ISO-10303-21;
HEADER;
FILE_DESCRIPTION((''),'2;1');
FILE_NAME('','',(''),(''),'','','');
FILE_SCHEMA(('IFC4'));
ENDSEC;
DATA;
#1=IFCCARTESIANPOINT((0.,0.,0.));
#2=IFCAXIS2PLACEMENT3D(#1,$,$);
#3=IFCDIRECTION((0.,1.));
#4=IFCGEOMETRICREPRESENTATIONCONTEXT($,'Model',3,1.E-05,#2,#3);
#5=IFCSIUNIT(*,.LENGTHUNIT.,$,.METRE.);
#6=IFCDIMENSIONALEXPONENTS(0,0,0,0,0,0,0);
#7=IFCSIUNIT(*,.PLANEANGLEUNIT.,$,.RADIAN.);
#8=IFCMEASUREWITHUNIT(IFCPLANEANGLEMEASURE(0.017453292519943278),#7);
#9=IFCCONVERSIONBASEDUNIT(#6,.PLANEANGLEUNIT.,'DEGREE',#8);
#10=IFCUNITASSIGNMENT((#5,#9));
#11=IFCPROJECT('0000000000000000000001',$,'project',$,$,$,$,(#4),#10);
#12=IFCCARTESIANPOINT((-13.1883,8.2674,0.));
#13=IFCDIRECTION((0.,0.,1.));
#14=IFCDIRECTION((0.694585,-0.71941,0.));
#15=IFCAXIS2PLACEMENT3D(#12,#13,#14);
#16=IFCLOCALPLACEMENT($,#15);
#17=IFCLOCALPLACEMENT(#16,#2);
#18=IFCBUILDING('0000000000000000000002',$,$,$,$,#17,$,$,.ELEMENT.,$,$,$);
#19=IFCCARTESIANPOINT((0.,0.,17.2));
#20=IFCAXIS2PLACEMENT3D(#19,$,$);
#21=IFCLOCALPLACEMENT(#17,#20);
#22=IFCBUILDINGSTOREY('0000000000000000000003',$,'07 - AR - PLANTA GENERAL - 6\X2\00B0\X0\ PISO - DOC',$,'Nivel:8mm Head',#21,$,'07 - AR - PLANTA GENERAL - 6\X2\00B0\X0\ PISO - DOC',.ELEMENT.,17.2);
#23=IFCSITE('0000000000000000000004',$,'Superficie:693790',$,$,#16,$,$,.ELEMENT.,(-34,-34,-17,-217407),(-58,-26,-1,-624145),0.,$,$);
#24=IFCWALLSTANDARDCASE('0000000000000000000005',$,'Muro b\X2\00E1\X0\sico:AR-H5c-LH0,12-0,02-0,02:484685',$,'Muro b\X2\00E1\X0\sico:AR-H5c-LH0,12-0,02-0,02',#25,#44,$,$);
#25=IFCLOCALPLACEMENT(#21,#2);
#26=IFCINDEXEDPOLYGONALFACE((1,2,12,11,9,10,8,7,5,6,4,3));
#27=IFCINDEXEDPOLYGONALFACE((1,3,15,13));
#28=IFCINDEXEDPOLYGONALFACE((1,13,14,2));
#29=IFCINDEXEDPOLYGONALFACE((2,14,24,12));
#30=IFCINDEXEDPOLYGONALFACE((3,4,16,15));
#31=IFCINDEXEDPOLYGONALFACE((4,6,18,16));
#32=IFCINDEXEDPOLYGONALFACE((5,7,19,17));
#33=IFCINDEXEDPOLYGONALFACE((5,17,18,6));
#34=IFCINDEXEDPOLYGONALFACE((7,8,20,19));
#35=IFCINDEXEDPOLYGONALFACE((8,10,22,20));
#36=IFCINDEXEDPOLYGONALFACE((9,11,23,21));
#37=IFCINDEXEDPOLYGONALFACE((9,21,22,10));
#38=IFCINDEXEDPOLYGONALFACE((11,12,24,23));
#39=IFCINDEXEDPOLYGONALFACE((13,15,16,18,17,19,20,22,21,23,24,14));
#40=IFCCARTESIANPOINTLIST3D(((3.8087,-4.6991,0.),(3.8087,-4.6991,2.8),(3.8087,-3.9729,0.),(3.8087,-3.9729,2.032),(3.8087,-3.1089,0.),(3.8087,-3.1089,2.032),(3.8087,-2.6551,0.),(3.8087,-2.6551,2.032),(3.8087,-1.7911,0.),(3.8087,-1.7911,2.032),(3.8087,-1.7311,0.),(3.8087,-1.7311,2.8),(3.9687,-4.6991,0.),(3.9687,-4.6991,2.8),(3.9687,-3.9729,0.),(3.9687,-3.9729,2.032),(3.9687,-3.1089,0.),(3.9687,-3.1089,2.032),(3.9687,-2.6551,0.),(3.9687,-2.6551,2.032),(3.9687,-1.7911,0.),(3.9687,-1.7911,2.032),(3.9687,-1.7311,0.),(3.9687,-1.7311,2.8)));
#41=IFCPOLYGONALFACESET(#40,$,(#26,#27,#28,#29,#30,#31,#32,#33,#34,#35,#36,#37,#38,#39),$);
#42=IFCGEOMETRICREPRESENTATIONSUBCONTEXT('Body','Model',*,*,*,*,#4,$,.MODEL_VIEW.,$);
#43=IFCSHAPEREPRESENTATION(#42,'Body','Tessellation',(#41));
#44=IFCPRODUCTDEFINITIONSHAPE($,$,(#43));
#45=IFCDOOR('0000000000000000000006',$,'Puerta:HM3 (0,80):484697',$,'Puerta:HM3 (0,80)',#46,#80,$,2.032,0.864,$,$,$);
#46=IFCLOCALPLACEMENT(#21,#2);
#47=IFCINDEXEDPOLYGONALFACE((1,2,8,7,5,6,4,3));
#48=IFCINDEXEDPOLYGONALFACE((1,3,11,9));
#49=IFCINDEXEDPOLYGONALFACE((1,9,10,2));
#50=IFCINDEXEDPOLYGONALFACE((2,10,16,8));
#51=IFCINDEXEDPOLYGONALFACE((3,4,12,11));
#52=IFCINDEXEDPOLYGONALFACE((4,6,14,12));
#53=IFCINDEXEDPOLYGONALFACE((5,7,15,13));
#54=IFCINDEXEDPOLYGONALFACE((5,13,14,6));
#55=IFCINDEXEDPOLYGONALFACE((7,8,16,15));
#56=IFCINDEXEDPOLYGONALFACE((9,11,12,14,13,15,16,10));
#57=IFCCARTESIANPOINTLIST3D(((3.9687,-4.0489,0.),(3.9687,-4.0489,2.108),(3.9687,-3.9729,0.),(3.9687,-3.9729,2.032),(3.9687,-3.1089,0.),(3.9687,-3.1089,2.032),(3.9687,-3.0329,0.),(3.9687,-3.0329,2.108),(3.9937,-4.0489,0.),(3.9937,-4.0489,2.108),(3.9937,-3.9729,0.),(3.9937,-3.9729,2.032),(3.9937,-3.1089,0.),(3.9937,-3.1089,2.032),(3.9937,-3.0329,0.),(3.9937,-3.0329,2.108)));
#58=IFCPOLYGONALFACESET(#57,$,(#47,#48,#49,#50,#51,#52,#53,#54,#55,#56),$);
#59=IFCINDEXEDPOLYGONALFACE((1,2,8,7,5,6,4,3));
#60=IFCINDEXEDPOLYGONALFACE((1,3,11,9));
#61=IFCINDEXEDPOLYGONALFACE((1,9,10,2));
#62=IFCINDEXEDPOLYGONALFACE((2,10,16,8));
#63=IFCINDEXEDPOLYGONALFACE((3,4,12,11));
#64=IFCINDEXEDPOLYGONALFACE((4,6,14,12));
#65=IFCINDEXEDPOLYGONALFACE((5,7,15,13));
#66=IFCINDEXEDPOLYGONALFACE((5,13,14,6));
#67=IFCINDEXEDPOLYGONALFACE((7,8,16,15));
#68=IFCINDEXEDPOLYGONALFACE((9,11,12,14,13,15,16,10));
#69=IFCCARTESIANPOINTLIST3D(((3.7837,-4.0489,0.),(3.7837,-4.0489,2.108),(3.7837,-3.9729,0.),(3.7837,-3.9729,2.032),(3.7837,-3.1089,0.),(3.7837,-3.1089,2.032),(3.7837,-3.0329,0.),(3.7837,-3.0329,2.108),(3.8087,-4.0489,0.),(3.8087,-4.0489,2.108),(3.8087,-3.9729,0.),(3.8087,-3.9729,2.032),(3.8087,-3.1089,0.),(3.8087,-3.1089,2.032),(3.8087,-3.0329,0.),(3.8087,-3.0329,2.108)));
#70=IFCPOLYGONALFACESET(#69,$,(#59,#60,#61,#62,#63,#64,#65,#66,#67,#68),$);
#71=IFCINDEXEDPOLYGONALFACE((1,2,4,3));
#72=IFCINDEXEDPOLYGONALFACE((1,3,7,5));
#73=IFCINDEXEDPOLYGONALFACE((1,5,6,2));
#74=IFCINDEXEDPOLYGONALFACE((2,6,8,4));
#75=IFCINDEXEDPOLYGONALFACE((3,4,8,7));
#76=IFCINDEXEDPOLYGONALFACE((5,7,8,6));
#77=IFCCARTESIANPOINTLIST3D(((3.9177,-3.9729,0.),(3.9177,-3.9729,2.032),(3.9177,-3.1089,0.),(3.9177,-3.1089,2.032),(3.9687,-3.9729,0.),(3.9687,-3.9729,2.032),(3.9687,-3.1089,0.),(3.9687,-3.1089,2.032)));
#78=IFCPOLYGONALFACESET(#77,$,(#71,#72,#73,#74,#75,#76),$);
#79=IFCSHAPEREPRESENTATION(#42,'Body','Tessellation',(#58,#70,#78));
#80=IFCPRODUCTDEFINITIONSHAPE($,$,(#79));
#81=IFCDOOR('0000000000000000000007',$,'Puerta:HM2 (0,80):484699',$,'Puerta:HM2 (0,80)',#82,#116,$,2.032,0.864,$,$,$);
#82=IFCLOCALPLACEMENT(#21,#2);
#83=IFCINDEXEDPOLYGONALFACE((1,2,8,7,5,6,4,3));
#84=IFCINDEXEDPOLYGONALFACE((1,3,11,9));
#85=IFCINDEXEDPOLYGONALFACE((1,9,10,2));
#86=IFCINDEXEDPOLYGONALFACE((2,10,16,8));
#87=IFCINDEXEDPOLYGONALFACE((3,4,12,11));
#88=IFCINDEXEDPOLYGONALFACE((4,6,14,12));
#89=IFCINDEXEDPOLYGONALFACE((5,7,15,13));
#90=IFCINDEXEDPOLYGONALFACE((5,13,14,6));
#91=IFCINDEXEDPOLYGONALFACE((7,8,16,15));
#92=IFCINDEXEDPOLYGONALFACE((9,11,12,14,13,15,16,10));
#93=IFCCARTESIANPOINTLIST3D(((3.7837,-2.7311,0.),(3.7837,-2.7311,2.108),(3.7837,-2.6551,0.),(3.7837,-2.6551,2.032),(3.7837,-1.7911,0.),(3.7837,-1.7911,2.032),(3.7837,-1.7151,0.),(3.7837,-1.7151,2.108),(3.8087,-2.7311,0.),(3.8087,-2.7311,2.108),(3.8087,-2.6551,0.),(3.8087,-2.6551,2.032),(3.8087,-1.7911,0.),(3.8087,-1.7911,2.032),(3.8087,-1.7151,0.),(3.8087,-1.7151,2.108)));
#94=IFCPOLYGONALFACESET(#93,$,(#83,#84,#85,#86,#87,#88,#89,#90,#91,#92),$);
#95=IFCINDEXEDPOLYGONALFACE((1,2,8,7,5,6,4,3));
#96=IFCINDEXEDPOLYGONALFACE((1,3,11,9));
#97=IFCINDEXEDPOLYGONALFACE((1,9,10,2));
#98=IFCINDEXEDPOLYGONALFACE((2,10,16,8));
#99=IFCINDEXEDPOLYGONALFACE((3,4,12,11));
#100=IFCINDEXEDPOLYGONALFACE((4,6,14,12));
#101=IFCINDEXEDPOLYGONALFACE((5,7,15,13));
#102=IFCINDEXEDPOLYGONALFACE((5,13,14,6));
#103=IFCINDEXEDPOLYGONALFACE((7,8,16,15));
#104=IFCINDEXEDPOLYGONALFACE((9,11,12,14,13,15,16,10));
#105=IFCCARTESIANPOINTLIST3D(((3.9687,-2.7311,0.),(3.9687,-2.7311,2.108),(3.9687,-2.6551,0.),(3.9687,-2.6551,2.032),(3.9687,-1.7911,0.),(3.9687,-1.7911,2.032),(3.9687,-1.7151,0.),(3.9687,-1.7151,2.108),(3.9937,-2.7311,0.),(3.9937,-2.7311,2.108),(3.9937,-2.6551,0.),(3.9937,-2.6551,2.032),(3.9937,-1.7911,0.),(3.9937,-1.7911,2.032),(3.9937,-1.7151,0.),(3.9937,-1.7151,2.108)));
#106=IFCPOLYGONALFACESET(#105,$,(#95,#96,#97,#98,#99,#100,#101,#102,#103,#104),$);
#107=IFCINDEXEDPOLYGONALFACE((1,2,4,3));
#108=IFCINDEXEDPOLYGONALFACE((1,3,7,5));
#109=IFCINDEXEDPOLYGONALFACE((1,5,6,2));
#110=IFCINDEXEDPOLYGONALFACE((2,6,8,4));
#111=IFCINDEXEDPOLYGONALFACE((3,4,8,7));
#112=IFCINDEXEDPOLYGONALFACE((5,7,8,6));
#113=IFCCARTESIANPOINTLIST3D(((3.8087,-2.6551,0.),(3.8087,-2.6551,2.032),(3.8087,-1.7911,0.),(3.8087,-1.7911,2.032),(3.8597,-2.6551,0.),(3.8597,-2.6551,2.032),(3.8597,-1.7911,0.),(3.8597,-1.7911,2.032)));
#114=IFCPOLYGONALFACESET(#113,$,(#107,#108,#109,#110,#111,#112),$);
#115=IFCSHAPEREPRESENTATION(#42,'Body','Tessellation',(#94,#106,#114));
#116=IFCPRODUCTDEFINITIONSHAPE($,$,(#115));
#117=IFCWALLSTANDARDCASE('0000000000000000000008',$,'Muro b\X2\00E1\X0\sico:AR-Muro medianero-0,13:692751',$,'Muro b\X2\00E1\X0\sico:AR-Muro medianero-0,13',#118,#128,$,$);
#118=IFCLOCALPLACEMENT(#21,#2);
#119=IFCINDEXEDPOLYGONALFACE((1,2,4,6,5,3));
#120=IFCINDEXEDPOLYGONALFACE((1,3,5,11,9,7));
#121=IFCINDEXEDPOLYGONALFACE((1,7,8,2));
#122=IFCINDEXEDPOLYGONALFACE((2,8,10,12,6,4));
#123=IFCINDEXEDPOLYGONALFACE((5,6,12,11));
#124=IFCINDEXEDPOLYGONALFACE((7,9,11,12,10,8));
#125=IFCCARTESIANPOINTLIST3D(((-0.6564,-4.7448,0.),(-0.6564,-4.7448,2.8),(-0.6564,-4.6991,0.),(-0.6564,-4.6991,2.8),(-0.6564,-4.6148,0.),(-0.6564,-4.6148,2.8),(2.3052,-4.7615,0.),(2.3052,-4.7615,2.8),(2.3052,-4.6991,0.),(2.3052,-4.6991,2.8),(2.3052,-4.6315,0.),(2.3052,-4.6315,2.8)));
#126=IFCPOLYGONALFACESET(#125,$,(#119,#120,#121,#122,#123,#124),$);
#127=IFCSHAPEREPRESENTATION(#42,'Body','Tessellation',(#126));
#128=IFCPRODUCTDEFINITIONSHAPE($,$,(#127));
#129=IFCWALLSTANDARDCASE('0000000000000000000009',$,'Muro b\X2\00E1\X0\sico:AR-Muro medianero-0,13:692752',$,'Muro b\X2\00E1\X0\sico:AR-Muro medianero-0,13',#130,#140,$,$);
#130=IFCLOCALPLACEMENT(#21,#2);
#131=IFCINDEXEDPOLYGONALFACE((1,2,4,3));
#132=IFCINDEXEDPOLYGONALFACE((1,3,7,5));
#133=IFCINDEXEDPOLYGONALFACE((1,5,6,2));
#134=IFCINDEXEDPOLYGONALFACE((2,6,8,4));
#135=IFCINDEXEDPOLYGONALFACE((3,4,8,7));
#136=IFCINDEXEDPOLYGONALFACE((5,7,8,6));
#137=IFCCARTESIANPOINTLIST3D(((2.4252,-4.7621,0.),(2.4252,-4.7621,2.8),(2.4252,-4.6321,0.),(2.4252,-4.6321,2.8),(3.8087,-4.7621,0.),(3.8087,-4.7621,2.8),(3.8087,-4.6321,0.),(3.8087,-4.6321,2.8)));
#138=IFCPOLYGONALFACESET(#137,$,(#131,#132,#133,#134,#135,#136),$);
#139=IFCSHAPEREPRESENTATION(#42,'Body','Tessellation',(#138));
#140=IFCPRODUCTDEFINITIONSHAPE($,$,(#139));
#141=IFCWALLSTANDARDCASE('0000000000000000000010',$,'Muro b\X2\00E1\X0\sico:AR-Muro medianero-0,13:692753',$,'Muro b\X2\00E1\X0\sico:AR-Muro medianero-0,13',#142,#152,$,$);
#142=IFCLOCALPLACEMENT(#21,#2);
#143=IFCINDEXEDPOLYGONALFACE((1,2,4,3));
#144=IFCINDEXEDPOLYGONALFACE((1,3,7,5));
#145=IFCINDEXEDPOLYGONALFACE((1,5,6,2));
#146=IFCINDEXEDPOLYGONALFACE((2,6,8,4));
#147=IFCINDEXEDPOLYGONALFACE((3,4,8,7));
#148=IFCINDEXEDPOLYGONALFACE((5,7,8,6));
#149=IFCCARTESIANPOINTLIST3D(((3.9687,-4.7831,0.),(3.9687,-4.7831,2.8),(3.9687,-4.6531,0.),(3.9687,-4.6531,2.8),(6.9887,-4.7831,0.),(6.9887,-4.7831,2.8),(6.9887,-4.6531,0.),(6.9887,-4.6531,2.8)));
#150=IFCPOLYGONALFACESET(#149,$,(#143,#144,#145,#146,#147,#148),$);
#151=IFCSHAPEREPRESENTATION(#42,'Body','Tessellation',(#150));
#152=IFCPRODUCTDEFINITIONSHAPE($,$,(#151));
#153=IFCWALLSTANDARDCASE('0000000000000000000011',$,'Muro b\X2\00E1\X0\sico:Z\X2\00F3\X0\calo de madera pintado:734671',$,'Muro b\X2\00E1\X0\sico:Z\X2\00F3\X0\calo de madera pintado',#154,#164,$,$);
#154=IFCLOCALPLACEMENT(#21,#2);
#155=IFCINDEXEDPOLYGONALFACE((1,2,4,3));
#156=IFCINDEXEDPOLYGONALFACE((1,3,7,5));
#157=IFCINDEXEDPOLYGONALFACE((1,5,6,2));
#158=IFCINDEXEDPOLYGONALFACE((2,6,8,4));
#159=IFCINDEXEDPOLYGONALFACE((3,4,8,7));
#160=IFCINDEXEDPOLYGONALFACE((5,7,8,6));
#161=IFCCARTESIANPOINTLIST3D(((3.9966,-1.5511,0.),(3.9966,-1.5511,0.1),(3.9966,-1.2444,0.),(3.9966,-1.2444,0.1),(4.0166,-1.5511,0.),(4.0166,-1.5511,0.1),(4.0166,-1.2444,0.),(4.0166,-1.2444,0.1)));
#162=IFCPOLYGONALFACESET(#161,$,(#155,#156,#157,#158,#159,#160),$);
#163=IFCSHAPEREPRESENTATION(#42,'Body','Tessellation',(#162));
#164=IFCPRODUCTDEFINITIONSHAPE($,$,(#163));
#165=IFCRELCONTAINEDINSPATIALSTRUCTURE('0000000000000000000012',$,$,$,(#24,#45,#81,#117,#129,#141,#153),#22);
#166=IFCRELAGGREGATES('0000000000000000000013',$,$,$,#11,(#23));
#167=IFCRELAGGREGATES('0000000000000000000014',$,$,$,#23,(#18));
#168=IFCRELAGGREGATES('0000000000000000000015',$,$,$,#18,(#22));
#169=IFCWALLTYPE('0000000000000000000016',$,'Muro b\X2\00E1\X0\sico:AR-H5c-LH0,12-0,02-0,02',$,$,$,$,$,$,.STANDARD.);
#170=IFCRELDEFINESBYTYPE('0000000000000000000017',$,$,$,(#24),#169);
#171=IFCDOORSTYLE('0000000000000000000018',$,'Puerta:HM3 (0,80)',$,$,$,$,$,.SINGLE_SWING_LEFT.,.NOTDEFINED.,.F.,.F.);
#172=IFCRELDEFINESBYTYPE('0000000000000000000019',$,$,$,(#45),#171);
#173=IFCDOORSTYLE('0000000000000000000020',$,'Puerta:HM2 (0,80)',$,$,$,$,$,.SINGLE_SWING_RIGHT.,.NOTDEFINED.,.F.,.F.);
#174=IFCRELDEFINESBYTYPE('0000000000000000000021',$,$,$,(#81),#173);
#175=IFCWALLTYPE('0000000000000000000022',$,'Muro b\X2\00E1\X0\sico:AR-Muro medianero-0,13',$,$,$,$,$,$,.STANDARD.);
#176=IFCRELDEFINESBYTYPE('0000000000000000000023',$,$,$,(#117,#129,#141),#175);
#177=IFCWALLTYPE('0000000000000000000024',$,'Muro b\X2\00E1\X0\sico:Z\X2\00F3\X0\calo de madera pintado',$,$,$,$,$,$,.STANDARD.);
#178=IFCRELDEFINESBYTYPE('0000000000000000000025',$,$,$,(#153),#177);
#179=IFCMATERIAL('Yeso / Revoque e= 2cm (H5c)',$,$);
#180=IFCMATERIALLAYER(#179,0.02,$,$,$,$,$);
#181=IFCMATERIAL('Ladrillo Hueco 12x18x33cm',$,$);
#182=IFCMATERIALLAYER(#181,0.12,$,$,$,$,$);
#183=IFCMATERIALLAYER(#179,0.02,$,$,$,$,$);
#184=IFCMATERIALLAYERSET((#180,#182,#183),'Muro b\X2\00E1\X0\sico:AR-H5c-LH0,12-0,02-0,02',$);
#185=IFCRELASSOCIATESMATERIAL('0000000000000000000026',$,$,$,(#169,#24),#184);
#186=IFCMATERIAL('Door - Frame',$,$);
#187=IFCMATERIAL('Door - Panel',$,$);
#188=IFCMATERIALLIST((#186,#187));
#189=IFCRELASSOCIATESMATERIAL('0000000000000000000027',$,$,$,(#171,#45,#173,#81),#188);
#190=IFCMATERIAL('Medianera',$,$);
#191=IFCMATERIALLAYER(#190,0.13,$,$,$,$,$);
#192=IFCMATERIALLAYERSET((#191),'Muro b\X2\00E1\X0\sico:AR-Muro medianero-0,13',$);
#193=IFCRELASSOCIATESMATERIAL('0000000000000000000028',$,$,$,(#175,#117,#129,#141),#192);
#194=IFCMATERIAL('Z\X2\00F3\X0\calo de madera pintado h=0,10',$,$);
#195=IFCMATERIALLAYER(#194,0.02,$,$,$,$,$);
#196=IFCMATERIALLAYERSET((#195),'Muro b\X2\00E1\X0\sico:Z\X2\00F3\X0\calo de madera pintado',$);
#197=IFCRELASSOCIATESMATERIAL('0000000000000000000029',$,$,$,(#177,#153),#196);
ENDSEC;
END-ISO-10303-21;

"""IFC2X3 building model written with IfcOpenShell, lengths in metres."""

from ifc_helpers import new_model, entity, si_unit, converted_unit, direction, frame, frame_2d, origin, place, context, subcontext, project, spatial, polyline, rectangle, outline, extrude, source, transform, mapped, material, material_list, layer, layer_set, layer_usage, type_object, type_shapes, element, fill, save


model = new_model("IFC2X3")

# Units and contexts
model_context = context("Model", 3, precision=1e-05, world=origin(), true_north=direction((0.0, 1.0)))
body_context = subcontext(model_context, "Body", "Model", "MODEL_VIEW")
ifc_project = project(units=[si_unit("LENGTHUNIT", "METRE"), converted_unit("PLANEANGLEUNIT", "DEGREE", entity("IfcPlaneAngleMeasure", 0.017453292519943278), si_unit("PLANEANGLEUNIT", "RADIAN"), dimensions=[0, 0, 0, 0, 0, 0, 0])], contexts=[model_context])

# Site, building, storey
site_placement = place(None, frame((-13.1883, 8.2674, 0.0), z_axis=(0.0, 0.0, 1.0), x_axis=(0.694585, -0.71941, 0.0)))
site = spatial("IfcSite", under=ifc_project, at=site_placement, Name="Superficie:693790", CompositionType="ELEMENT", RefLatitude=(-34, -34, -17, -217407), RefLongitude=(-58, -26, -1, -624145), RefElevation=0.0)
building_placement = place(site_placement, origin())
building = spatial("IfcBuilding", under=site, at=building_placement, CompositionType="ELEMENT")
storey_placement = place(building_placement, frame((0.0, 0.0, 17.2)))
storey = spatial("IfcBuildingStorey", under=building, at=storey_placement, Name="07 - AR - PLANTA GENERAL - 6° PISO - DOC", ObjectType="Nivel:8mm Head", LongName="07 - AR - PLANTA GENERAL - 6° PISO - DOC", CompositionType="ELEMENT", Elevation=17.2)

# Shared definitions
ifc_material_1 = material(Name="Door - Frame")
ifc_material_2 = material(Name="Door - Panel")
ifc_material_list = material_list([ifc_material_1, ifc_material_2])

# Wall, openings, doors
ifc_material_3 = material(Name="Yeso / Revoque e= 2cm (H5c)")
ifc_layer_1 = layer(ifc_material_3, 0.02)
ifc_material_4 = material(Name="Ladrillo Hueco 12x18x33cm")
ifc_layer_2 = layer(ifc_material_4, 0.12)
ifc_layer_3 = layer(ifc_material_3, 0.02)
ifc_layer_set_1 = layer_set([ifc_layer_1, ifc_layer_2, ifc_layer_3], Name="Muro básico:AR-H5c-LH0,12-0,02-0,02")
wall_type_1 = type_object("IfcWallType", Name="Muro básico:AR-H5c-LH0,12-0,02-0,02", PredefinedType="STANDARD", material=ifc_layer_set_1)
ifc_layer_usage_1 = layer_usage(ifc_layer_set_1, "AXIS2", "NEGATIVE", 0.08)
wall_1_placement = place(storey_placement, frame((3.8887, -1.7311, 0.0), z_axis=(0.0, 0.0, 1.0), x_axis=(0.0, -1.0, 0.0)))
wall_1 = element("IfcWallStandardCase", 1, at=wall_1_placement, inside=storey, type_object=wall_type_1, material=ifc_layer_usage_1, Name="Muro básico:AR-H5c-LH0,12-0,02-0,02:484685", ObjectType="Muro básico:AR-H5c-LH0,12-0,02-0,02", context=body_context, shape_type="SweptSolid", body=[
    extrude(rectangle(XDim=2.968, YDim=0.16, at=frame_2d((1.484, 0.0), x_axis=(-1.0, 0.0))), origin(), (0.0, 0.0, 1.0), 2.8),
])
opening_1_placement = place(wall_1_placement, frame((1.3778, -0.08, 0.0)))
opening_1 = element("IfcOpeningElement", 2, at=opening_1_placement, cuts=wall_1, ObjectType="Opening", context=body_context, shape_type="SweptSolid", body=[
    extrude(rectangle(XDim=0.864, YDim=2.032, at=frame_2d((1.016, 0.432), x_axis=(0.0, -1.0))), frame((0.0, 0.0, 0.0), z_axis=(0.0, 1.0, 0.0), x_axis=(0.0, 0.0, 1.0)), (0.0, 0.0, 1.0), 0.16),
])
opening_2_placement = place(wall_1_placement, frame((0.924, 0.08, 0.0)))
opening_2 = element("IfcOpeningElement", 3, at=opening_2_placement, cuts=wall_1, ObjectType="Opening", context=body_context, shape_type="SweptSolid", body=[
    extrude(rectangle(XDim=0.864, YDim=2.032, at=frame_2d((1.016, 0.432), x_axis=(0.0, 1.0))), frame((0.0, 0.0, 0.0), z_axis=(0.0, -1.0, 0.0), x_axis=(0.0, 0.0, 1.0)), (0.0, 0.0, 1.0), 0.16),
])
door_style_1 = type_object("IfcDoorStyle", Name="Puerta:HM3 (0,80)", ConstructionType="NOTDEFINED", OperationType="SINGLE_SWING_LEFT", ParameterTakesPrecedence=False, Sizeable=False, material=ifc_material_list)
shared_shape_1 = source(origin(), body_context, "Body", "SweptSolid", [
    extrude(outline(polyline([(-0.508, -1.073), (0.508, -1.073), (0.508, 1.035), (0.432, 1.035), (0.432, -0.997), (-0.432, -0.997), (-0.432, 1.035), (-0.508, 1.035), (-0.508, -1.073)])), frame((0.432, 0.185, 1.035), z_axis=(0.0, -1.0, 0.0), x_axis=(-1.0, 0.0, 0.0)), (0.0, 0.0, 1.0), 0.025),
    extrude(outline(polyline([(-1.073, -0.508), (1.035, -0.508), (1.035, -0.432), (-0.997, -0.432), (-0.997, 0.432), (1.035, 0.432), (1.035, 0.508), (-1.073, 0.508), (-1.073, -0.508)])), frame((0.432, 0.0, 1.035), z_axis=(0.0, -1.0, 0.0), x_axis=(0.0, 0.0, -1.0)), (0.0, 0.0, 1.0), 0.025),
    extrude(rectangle(XDim=0.864, YDim=0.051, at=frame_2d((0.0, 0.0), x_axis=(1.0, 0.0))), frame((0.432, 0.1345, 0.0)), (0.0, 0.0, 1.0), 2.032),
])
type_shapes(door_style_1, [shared_shape_1])
door_1_placement = place(opening_1_placement, origin())
door_1 = element("IfcDoor", 4, at=door_1_placement, inside=storey, type_object=door_style_1, material=ifc_material_list, Name="Puerta:HM3 (0,80):484697", ObjectType="Puerta:HM3 (0,80)", OverallHeight=2.032, OverallWidth=0.864, context=body_context, shape_type="MappedRepresentation", body=[
    mapped(shared_shape_1, transform((0.0, 0.0, 0.0), scale=1.0)),
])
fill(opening_1, door_1)
door_style_2 = type_object("IfcDoorStyle", Name="Puerta:HM2 (0,80)", ConstructionType="NOTDEFINED", OperationType="SINGLE_SWING_RIGHT", ParameterTakesPrecedence=False, Sizeable=False, material=ifc_material_list)
shared_shape_2 = source(origin(), body_context, "Body", "SweptSolid", [
    extrude(outline(polyline([(-0.508, -1.073), (0.508, -1.073), (0.508, 1.035), (0.432, 1.035), (0.432, -0.997), (-0.432, -0.997), (-0.432, 1.035), (-0.508, 1.035), (-0.508, -1.073)])), frame((0.432, 0.16, 1.035), z_axis=(0.0, 1.0, 0.0), x_axis=(1.0, 0.0, 0.0)), (0.0, 0.0, 1.0), 0.025),
    extrude(outline(polyline([(-1.073, -0.508), (1.035, -0.508), (1.035, -0.432), (-0.997, -0.432), (-0.997, 0.432), (1.035, 0.432), (1.035, 0.508), (-1.073, 0.508), (-1.073, -0.508)])), frame((0.432, -0.025, 1.035), z_axis=(0.0, 1.0, 0.0), x_axis=(0.0, 0.0, -1.0)), (0.0, 0.0, 1.0), 0.025),
    extrude(rectangle(XDim=0.051, YDim=0.864, at=frame_2d((0.0, 0.0), x_axis=(1.0, 0.0))), frame((0.432, 0.1345, 0.0), z_axis=(0.0, 0.0, 1.0), x_axis=(0.0, 1.0, 0.0)), (0.0, 0.0, 1.0), 2.032),
])
type_shapes(door_style_2, [shared_shape_2])
door_2_placement = place(opening_2_placement, frame((0.0, 0.0, 0.0), z_axis=(0.0, 0.0, 1.0), x_axis=(-1.0, 0.0, 0.0)))
door_2 = element("IfcDoor", 5, at=door_2_placement, inside=storey, type_object=door_style_2, material=ifc_material_list, Name="Puerta:HM2 (0,80):484699", ObjectType="Puerta:HM2 (0,80)", OverallHeight=2.032, OverallWidth=0.864, context=body_context, shape_type="MappedRepresentation", body=[
    mapped(shared_shape_2, transform((0.0, 0.0, 0.0), scale=1.0)),
])
fill(opening_2, door_2)

# Walls
ifc_material_5 = material(Name="Medianera")
ifc_layer_4 = layer(ifc_material_5, 0.13)
ifc_layer_set_2 = layer_set([ifc_layer_4], Name="Muro básico:AR-Muro medianero-0,13")
ifc_layer_usage_2 = layer_usage(ifc_layer_set_2, "AXIS2", "NEGATIVE", 0.065)
wall_type_2 = type_object("IfcWallType", Name="Muro básico:AR-Muro medianero-0,13", PredefinedType="STANDARD", material=ifc_layer_set_2)
wall_2_placement = place(storey_placement, frame((-0.6568, -4.6798, 0.0), z_axis=(0.0, 0.0, 1.0), x_axis=(0.999984, -0.005619, 0.0)))
element("IfcWallStandardCase", 6, at=wall_2_placement, inside=storey, type_object=wall_type_2, material=ifc_layer_usage_2, Name="Muro básico:AR-Muro medianero-0,13:692751", ObjectType="Muro básico:AR-Muro medianero-0,13", context=body_context, shape_type="SweptSolid", body=[
    extrude(outline(polyline([(2.9623, -0.065), (2.962, -0.0027), (2.9616, 0.065), (0.0, 0.065), (0.0005, -0.0193), (0.0007, -0.065), (2.9623, -0.065)])), origin(), (0.0, 0.0, 1.0), 2.8),
])
ifc_layer_usage_3 = layer_usage(ifc_layer_set_2, "AXIS2", "NEGATIVE", 0.065)
wall_3_placement = place(storey_placement, frame((2.4252, -4.6971, 0.0)))
element("IfcWallStandardCase", 7, at=wall_3_placement, inside=storey, type_object=wall_type_2, material=ifc_layer_usage_3, Name="Muro básico:AR-Muro medianero-0,13:692752", ObjectType="Muro básico:AR-Muro medianero-0,13", context=body_context, shape_type="SweptSolid", body=[
    extrude(rectangle(XDim=1.3835, YDim=0.13, at=frame_2d((0.6918, 0.0), x_axis=(-1.0, 0.0))), origin(), (0.0, 0.0, 1.0), 2.8),
])
ifc_layer_usage_4 = layer_usage(ifc_layer_set_2, "AXIS2", "NEGATIVE", 0.065)
wall_4_placement = place(storey_placement, frame((3.9687, -4.7181, 0.0)))
element("IfcWallStandardCase", 8, at=wall_4_placement, inside=storey, type_object=wall_type_2, material=ifc_layer_usage_4, Name="Muro básico:AR-Muro medianero-0,13:692753", ObjectType="Muro básico:AR-Muro medianero-0,13", context=body_context, shape_type="SweptSolid", body=[
    extrude(rectangle(XDim=3.02, YDim=0.13, at=frame_2d((1.51, 0.0), x_axis=(-1.0, 0.0))), origin(), (0.0, 0.0, 1.0), 2.8),
])
ifc_material_6 = material(Name="Zócalo de madera pintado h=0,10")
ifc_layer_5 = layer(ifc_material_6, 0.02)
ifc_layer_set_3 = layer_set([ifc_layer_5], Name="Muro básico:Zócalo de madera pintado")
ifc_layer_usage_5 = layer_usage(ifc_layer_set_3, "AXIS2", "NEGATIVE", 0.01)
wall_type_3 = type_object("IfcWallType", Name="Muro básico:Zócalo de madera pintado", PredefinedType="STANDARD", material=ifc_layer_set_3)
wall_5_placement = place(storey_placement, frame((4.0066, -1.5511, 0.0), z_axis=(0.0, 0.0, 1.0), x_axis=(0.0, 1.0, 0.0)))
element("IfcWallStandardCase", 9, at=wall_5_placement, inside=storey, type_object=wall_type_3, material=ifc_layer_usage_5, Name="Muro básico:Zócalo de madera pintado:734671", ObjectType="Muro básico:Zócalo de madera pintado", context=body_context, shape_type="SweptSolid", body=[
    extrude(rectangle(XDim=0.3066, YDim=0.02, at=frame_2d((0.1533, 0.0), x_axis=(-1.0, 0.0))), origin(), (0.0, 0.0, 1.0), 0.1),
])

save(model, "model.ifc")
